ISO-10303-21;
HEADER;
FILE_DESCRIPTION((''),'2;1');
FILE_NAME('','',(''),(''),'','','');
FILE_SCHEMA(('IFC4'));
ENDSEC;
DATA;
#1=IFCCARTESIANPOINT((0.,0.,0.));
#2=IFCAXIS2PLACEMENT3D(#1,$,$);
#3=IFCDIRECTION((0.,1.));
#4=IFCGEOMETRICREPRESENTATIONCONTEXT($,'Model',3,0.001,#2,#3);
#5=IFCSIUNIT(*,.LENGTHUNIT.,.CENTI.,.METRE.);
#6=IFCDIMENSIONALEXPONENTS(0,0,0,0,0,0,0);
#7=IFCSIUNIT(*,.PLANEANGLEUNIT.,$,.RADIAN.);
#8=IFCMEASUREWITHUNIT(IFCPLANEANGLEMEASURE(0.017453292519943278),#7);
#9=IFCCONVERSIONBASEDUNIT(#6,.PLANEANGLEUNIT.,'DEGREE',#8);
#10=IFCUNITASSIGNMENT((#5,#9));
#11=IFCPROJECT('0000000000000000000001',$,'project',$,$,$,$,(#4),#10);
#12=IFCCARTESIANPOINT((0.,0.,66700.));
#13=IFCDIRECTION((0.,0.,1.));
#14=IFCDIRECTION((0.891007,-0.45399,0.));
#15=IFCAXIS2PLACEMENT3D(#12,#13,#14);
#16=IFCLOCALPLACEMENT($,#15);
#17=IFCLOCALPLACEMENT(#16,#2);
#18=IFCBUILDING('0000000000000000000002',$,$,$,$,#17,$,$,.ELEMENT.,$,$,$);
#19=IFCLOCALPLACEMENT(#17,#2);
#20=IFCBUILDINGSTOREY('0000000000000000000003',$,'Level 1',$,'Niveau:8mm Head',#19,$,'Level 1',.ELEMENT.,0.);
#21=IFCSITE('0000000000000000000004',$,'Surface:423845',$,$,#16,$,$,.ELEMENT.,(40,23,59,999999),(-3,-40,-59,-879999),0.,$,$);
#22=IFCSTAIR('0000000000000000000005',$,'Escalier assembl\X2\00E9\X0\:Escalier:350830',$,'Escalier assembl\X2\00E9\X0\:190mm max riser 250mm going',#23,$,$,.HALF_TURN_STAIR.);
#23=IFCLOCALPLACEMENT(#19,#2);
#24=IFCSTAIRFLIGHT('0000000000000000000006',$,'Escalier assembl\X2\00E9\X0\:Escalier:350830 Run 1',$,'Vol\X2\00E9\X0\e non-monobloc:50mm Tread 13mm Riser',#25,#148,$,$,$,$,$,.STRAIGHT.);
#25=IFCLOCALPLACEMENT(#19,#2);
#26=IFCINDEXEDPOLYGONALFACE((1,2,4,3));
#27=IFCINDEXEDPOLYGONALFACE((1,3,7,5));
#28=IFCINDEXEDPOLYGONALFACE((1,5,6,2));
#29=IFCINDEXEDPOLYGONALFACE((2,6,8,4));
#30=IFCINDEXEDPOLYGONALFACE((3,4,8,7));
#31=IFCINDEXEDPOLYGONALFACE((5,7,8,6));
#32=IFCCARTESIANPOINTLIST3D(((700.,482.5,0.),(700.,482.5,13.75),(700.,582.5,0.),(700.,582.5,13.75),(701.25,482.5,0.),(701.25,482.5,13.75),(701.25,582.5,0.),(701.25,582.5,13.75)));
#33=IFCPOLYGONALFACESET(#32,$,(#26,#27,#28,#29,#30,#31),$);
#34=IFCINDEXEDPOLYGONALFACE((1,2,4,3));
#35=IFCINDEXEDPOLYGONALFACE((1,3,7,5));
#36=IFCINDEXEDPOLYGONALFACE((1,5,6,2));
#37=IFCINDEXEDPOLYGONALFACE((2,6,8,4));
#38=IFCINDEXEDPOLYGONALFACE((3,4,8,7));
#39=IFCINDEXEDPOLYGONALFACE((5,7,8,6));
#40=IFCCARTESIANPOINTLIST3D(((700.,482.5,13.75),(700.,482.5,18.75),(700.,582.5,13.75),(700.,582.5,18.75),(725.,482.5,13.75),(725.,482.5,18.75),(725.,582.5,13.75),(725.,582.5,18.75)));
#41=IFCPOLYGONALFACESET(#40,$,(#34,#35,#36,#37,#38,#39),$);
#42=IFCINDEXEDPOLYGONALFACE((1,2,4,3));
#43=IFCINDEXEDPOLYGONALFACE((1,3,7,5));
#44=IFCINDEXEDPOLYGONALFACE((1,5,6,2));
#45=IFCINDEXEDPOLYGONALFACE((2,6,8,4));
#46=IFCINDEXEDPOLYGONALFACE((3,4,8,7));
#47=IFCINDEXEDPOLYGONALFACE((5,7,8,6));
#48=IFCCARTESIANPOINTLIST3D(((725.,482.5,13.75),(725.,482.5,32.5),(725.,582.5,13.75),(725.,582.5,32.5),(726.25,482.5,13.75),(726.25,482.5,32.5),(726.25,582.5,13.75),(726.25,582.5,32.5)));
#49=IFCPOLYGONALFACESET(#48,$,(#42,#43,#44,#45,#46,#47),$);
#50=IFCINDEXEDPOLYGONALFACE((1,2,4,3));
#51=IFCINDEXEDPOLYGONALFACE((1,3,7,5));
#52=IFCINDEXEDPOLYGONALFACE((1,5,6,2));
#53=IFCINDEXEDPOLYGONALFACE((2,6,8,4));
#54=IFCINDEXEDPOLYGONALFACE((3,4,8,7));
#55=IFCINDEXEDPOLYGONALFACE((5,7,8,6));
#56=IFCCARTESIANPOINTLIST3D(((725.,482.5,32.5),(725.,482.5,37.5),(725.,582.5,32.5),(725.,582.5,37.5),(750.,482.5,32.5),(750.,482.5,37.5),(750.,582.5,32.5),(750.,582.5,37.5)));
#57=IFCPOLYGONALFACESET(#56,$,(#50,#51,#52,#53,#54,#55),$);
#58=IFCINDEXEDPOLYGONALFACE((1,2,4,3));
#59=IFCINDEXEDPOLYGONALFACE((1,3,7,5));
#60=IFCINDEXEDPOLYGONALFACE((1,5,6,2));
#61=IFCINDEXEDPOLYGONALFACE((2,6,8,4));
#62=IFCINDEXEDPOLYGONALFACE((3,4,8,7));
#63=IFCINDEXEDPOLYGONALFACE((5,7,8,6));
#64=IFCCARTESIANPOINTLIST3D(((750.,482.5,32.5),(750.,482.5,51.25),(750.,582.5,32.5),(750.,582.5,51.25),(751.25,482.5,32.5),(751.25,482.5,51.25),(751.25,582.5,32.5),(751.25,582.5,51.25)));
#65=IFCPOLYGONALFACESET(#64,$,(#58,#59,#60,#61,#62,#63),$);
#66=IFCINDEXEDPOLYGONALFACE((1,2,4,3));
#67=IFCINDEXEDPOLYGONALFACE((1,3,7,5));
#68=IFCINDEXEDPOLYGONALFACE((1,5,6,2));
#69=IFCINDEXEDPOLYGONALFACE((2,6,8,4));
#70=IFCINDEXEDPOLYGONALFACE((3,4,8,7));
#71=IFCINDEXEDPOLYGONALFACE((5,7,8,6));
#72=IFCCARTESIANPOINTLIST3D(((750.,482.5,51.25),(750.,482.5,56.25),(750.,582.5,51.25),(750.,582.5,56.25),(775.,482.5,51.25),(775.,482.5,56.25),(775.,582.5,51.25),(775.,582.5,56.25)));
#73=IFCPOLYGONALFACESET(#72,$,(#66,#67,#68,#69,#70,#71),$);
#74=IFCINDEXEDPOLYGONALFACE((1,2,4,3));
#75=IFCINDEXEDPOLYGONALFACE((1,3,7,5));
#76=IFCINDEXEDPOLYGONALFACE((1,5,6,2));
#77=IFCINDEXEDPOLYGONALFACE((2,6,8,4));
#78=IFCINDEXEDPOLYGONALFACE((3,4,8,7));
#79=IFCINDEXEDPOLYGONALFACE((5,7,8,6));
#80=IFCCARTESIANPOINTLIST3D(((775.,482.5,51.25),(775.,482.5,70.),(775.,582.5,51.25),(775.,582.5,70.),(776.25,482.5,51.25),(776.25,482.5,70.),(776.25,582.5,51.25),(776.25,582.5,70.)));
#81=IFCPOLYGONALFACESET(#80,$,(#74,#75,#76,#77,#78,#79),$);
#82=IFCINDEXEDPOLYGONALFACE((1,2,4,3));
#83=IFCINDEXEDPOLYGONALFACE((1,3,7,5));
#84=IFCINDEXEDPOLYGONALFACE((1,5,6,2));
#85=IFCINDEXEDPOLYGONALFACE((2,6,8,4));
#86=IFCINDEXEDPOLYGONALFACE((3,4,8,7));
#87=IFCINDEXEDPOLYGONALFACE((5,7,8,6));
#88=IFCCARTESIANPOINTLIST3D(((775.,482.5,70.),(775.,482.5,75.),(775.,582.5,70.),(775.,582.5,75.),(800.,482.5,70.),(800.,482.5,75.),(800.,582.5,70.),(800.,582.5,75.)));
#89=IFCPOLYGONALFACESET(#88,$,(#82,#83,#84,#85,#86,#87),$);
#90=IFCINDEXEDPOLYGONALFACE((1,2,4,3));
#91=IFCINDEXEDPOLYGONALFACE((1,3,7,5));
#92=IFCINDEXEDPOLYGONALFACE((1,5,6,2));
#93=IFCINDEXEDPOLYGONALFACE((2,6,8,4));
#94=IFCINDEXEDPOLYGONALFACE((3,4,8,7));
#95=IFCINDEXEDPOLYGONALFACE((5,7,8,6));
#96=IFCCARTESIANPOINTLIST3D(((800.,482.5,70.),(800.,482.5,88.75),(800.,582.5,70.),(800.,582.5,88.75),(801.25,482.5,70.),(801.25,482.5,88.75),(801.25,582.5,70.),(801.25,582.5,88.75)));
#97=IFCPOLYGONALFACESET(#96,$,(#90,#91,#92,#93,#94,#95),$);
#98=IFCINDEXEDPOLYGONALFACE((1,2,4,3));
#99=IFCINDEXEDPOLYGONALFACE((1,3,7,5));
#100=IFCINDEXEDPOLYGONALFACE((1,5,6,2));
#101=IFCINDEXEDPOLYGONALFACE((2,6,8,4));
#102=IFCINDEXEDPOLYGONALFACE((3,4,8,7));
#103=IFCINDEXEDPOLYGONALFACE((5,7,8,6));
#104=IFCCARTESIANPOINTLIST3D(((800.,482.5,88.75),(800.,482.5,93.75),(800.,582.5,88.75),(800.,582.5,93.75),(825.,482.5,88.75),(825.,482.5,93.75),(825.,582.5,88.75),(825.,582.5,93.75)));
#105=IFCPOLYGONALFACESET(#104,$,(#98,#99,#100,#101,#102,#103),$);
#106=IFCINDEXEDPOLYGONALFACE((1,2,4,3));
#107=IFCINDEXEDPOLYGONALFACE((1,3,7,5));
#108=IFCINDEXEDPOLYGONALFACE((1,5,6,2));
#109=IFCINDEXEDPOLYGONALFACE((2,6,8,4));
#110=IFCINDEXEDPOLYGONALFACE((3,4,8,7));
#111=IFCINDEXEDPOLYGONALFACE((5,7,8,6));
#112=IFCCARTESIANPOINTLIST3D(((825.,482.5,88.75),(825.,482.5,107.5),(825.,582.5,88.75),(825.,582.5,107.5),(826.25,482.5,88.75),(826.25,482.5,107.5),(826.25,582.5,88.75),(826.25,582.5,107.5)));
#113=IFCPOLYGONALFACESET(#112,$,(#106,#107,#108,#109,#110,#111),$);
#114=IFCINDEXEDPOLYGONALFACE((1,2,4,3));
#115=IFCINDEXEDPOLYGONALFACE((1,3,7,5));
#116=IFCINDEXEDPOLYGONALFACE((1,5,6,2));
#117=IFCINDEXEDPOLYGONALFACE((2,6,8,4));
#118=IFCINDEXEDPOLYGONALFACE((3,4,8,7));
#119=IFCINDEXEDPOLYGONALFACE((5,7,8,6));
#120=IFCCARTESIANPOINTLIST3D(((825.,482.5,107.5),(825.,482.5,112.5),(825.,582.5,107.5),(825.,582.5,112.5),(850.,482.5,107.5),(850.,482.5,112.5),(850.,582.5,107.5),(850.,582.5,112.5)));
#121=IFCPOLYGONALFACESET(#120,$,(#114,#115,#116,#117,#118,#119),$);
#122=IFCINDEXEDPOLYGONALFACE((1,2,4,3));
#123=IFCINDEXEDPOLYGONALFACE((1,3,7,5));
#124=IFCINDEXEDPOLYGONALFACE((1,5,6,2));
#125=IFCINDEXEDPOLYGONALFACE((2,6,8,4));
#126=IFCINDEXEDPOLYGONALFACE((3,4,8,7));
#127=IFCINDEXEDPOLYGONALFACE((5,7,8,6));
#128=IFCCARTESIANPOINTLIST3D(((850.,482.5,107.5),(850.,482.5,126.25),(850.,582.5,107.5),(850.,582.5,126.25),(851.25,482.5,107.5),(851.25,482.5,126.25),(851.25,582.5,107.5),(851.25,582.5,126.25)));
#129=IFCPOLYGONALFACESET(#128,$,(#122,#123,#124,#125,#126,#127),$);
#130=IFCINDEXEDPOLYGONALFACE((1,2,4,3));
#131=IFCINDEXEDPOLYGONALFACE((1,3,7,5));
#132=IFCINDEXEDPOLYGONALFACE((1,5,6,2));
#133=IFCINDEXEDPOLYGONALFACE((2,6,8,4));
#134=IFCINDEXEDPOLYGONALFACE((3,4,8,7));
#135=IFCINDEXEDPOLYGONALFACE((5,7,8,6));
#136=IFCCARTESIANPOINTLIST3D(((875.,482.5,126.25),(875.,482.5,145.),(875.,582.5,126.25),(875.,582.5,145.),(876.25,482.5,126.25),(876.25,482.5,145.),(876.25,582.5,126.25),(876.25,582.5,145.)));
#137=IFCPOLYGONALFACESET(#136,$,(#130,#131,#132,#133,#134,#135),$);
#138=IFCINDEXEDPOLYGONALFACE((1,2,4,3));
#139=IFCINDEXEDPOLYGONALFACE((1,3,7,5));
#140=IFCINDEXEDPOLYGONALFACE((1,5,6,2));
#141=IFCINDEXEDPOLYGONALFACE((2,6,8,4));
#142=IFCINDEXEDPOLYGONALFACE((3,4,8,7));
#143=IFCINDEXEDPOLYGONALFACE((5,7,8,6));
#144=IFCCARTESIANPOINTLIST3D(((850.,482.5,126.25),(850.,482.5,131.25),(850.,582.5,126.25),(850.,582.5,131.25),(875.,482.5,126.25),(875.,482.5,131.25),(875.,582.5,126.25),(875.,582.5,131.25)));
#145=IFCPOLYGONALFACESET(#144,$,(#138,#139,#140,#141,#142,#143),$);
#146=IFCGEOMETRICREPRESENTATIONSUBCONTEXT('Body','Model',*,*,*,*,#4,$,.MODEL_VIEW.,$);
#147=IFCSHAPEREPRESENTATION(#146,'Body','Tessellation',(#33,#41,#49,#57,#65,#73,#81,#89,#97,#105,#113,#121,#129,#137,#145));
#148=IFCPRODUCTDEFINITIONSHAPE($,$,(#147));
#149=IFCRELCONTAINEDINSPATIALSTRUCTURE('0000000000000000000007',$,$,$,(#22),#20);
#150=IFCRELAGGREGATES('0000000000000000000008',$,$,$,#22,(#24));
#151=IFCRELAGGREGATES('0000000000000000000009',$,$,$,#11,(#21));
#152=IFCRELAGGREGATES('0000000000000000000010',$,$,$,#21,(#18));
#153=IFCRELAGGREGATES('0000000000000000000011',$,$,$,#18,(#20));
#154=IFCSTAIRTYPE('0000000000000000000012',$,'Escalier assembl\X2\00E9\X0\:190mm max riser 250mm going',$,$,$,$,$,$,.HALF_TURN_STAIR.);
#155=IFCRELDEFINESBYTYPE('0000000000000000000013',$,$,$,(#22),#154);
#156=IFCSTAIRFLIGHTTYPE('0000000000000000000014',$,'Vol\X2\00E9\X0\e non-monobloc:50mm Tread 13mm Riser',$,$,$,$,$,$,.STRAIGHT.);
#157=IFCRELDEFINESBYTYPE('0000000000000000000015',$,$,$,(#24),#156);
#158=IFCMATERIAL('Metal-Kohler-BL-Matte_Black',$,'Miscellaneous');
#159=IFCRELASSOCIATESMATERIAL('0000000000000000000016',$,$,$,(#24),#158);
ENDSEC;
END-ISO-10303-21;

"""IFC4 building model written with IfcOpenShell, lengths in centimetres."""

from ifc_helpers import new_model, entity, si_unit, converted_unit, direction, frame, frame_2d, origin, place, context, subcontext, project, spatial, rectangle, extrude, material, type_object, element, aggregate, save


model = new_model("IFC4")

# Units and contexts
model_context = context("Model", 3, precision=0.001, world=origin(), true_north=direction((0.0, 1.0)))
body_context = subcontext(model_context, "Body", "Model", "MODEL_VIEW")
ifc_project = project(units=[si_unit("LENGTHUNIT", "METRE", prefix="CENTI"), converted_unit("PLANEANGLEUNIT", "DEGREE", entity("IfcPlaneAngleMeasure", 0.017453292519943278), si_unit("PLANEANGLEUNIT", "RADIAN"), dimensions=[0, 0, 0, 0, 0, 0, 0])], contexts=[model_context])

# Site, building, storey
site_placement = place(None, frame((0.0, 0.0, 66700.0), z_axis=(0.0, 0.0, 1.0), x_axis=(0.891007, -0.45399, 0.0)))
site = spatial("IfcSite", under=ifc_project, at=site_placement, Name="Surface:423845", CompositionType="ELEMENT", RefLatitude=(40, 23, 59, 999999), RefLongitude=(-3, -40, -59, -879999), RefElevation=0.0)
building_placement = place(site_placement, origin())
building = spatial("IfcBuilding", under=site, at=building_placement, CompositionType="ELEMENT")
storey_placement = place(building_placement, origin())
storey = spatial("IfcBuildingStorey", under=building, at=storey_placement, Name="Level 1", ObjectType="Niveau:8mm Head", LongName="Level 1", CompositionType="ELEMENT", Elevation=0.0)

# Shared definitions
ifc_material_1 = material(Name="Metal-Kohler-BL-Matte_Black", Category="Miscellaneous")

# Stair
stair_type = type_object("IfcStairType", Name="Escalier assemblé:190mm max riser 250mm going", PredefinedType="HALF_TURN_STAIR")
stair_placement = place(storey_placement, origin())
stair = element("IfcStair", 1, at=stair_placement, inside=storey, type_object=stair_type, Name="Escalier assemblé:Escalier:350830", ObjectType="Escalier assemblé:190mm max riser 250mm going", PredefinedType="HALF_TURN_STAIR")

# Stair flight
stair_flight_type = type_object("IfcStairFlightType", Name="Volée non-monobloc:50mm Tread 13mm Riser", PredefinedType="STRAIGHT")
stair_flight_1_placement = place(stair_placement, origin())
stair_flight_1 = element("IfcStairFlight", 2, at=stair_flight_1_placement, type_object=stair_flight_type, material=ifc_material_1, Name="Escalier assemblé:Escalier:350830 Run 1", ObjectType="Volée non-monobloc:50mm Tread 13mm Riser", PredefinedType="STRAIGHT", context=body_context, shape_type="SweptSolid", body=[
    extrude(rectangle(XDim=100.0, YDim=1.25, at=frame_2d((0.0, 0.0), x_axis=(1.0, 0.0))), frame((700.63, 532.5, 0.0), z_axis=(0.0, 0.0, 1.0), x_axis=(0.0, 1.0, 0.0)), (0.0, 0.0, 1.0), 13.75),
    extrude(rectangle(XDim=25.0, YDim=100.0, at=frame_2d((0.0, 0.0), x_axis=(1.0, 0.0))), frame((712.5, 532.5, 13.75), z_axis=(0.0, 0.0, 1.0), x_axis=(-1.0, 0.0, 0.0)), (0.0, 0.0, 1.0), 5.0),
    extrude(rectangle(XDim=100.0, YDim=1.25, at=frame_2d((0.0, 0.0), x_axis=(1.0, 0.0))), frame((725.63, 532.5, 13.75), z_axis=(0.0, 0.0, 1.0), x_axis=(0.0, 1.0, 0.0)), (0.0, 0.0, 1.0), 18.75),
    extrude(rectangle(XDim=25.0, YDim=100.0, at=frame_2d((0.0, 0.0), x_axis=(1.0, 0.0))), frame((737.5, 532.5, 32.5), z_axis=(0.0, 0.0, 1.0), x_axis=(-1.0, 0.0, 0.0)), (0.0, 0.0, 1.0), 5.0),
    extrude(rectangle(XDim=100.0, YDim=1.25, at=frame_2d((0.0, 0.0), x_axis=(1.0, 0.0))), frame((750.63, 532.5, 32.5), z_axis=(0.0, 0.0, 1.0), x_axis=(0.0, 1.0, 0.0)), (0.0, 0.0, 1.0), 18.75),
    extrude(rectangle(XDim=25.0, YDim=100.0, at=frame_2d((0.0, 0.0), x_axis=(1.0, 0.0))), frame((762.5, 532.5, 51.25), z_axis=(0.0, 0.0, 1.0), x_axis=(-1.0, 0.0, 0.0)), (0.0, 0.0, 1.0), 5.0),
    extrude(rectangle(XDim=100.0, YDim=1.25, at=frame_2d((0.0, 0.0), x_axis=(1.0, 0.0))), frame((775.63, 532.5, 51.25), z_axis=(0.0, 0.0, 1.0), x_axis=(0.0, 1.0, 0.0)), (0.0, 0.0, 1.0), 18.75),
    extrude(rectangle(XDim=25.0, YDim=100.0, at=frame_2d((0.0, 0.0), x_axis=(1.0, 0.0))), frame((787.5, 532.5, 70.0), z_axis=(0.0, 0.0, 1.0), x_axis=(-1.0, 0.0, 0.0)), (0.0, 0.0, 1.0), 5.0),
    extrude(rectangle(XDim=100.0, YDim=1.25, at=frame_2d((0.0, 0.0), x_axis=(1.0, 0.0))), frame((800.63, 532.5, 70.0), z_axis=(0.0, 0.0, 1.0), x_axis=(0.0, 1.0, 0.0)), (0.0, 0.0, 1.0), 18.75),
    extrude(rectangle(XDim=25.0, YDim=100.0, at=frame_2d((0.0, 0.0), x_axis=(1.0, 0.0))), frame((812.5, 532.5, 88.75), z_axis=(0.0, 0.0, 1.0), x_axis=(-1.0, 0.0, 0.0)), (0.0, 0.0, 1.0), 5.0),
    extrude(rectangle(XDim=100.0, YDim=1.25, at=frame_2d((0.0, 0.0), x_axis=(1.0, 0.0))), frame((825.63, 532.5, 88.75), z_axis=(0.0, 0.0, 1.0), x_axis=(0.0, 1.0, 0.0)), (0.0, 0.0, 1.0), 18.75),
    extrude(rectangle(XDim=25.0, YDim=100.0, at=frame_2d((0.0, 0.0), x_axis=(1.0, 0.0))), frame((837.5, 532.5, 107.5), z_axis=(0.0, 0.0, 1.0), x_axis=(-1.0, 0.0, 0.0)), (0.0, 0.0, 1.0), 5.0),
    extrude(rectangle(XDim=100.0, YDim=1.25, at=frame_2d((0.0, 0.0), x_axis=(1.0, 0.0))), frame((850.63, 532.5, 107.5), z_axis=(0.0, 0.0, 1.0), x_axis=(0.0, 1.0, 0.0)), (0.0, 0.0, 1.0), 18.75),
    extrude(rectangle(XDim=100.0, YDim=1.25, at=frame_2d((0.0, 0.0), x_axis=(1.0, 0.0))), frame((875.63, 532.5, 126.25), z_axis=(0.0, 0.0, 1.0), x_axis=(0.0, 1.0, 0.0)), (0.0, 0.0, 1.0), 18.75),
    extrude(rectangle(XDim=25.0, YDim=100.0, at=frame_2d((0.0, 0.0), x_axis=(1.0, 0.0))), frame((862.5, 532.5, 126.25), z_axis=(0.0, 0.0, 1.0), x_axis=(-1.0, 0.0, 0.0)), (0.0, 0.0, 1.0), 5.0),
])
aggregate(stair, [stair_flight_1])

save(model, "model.ifc")
